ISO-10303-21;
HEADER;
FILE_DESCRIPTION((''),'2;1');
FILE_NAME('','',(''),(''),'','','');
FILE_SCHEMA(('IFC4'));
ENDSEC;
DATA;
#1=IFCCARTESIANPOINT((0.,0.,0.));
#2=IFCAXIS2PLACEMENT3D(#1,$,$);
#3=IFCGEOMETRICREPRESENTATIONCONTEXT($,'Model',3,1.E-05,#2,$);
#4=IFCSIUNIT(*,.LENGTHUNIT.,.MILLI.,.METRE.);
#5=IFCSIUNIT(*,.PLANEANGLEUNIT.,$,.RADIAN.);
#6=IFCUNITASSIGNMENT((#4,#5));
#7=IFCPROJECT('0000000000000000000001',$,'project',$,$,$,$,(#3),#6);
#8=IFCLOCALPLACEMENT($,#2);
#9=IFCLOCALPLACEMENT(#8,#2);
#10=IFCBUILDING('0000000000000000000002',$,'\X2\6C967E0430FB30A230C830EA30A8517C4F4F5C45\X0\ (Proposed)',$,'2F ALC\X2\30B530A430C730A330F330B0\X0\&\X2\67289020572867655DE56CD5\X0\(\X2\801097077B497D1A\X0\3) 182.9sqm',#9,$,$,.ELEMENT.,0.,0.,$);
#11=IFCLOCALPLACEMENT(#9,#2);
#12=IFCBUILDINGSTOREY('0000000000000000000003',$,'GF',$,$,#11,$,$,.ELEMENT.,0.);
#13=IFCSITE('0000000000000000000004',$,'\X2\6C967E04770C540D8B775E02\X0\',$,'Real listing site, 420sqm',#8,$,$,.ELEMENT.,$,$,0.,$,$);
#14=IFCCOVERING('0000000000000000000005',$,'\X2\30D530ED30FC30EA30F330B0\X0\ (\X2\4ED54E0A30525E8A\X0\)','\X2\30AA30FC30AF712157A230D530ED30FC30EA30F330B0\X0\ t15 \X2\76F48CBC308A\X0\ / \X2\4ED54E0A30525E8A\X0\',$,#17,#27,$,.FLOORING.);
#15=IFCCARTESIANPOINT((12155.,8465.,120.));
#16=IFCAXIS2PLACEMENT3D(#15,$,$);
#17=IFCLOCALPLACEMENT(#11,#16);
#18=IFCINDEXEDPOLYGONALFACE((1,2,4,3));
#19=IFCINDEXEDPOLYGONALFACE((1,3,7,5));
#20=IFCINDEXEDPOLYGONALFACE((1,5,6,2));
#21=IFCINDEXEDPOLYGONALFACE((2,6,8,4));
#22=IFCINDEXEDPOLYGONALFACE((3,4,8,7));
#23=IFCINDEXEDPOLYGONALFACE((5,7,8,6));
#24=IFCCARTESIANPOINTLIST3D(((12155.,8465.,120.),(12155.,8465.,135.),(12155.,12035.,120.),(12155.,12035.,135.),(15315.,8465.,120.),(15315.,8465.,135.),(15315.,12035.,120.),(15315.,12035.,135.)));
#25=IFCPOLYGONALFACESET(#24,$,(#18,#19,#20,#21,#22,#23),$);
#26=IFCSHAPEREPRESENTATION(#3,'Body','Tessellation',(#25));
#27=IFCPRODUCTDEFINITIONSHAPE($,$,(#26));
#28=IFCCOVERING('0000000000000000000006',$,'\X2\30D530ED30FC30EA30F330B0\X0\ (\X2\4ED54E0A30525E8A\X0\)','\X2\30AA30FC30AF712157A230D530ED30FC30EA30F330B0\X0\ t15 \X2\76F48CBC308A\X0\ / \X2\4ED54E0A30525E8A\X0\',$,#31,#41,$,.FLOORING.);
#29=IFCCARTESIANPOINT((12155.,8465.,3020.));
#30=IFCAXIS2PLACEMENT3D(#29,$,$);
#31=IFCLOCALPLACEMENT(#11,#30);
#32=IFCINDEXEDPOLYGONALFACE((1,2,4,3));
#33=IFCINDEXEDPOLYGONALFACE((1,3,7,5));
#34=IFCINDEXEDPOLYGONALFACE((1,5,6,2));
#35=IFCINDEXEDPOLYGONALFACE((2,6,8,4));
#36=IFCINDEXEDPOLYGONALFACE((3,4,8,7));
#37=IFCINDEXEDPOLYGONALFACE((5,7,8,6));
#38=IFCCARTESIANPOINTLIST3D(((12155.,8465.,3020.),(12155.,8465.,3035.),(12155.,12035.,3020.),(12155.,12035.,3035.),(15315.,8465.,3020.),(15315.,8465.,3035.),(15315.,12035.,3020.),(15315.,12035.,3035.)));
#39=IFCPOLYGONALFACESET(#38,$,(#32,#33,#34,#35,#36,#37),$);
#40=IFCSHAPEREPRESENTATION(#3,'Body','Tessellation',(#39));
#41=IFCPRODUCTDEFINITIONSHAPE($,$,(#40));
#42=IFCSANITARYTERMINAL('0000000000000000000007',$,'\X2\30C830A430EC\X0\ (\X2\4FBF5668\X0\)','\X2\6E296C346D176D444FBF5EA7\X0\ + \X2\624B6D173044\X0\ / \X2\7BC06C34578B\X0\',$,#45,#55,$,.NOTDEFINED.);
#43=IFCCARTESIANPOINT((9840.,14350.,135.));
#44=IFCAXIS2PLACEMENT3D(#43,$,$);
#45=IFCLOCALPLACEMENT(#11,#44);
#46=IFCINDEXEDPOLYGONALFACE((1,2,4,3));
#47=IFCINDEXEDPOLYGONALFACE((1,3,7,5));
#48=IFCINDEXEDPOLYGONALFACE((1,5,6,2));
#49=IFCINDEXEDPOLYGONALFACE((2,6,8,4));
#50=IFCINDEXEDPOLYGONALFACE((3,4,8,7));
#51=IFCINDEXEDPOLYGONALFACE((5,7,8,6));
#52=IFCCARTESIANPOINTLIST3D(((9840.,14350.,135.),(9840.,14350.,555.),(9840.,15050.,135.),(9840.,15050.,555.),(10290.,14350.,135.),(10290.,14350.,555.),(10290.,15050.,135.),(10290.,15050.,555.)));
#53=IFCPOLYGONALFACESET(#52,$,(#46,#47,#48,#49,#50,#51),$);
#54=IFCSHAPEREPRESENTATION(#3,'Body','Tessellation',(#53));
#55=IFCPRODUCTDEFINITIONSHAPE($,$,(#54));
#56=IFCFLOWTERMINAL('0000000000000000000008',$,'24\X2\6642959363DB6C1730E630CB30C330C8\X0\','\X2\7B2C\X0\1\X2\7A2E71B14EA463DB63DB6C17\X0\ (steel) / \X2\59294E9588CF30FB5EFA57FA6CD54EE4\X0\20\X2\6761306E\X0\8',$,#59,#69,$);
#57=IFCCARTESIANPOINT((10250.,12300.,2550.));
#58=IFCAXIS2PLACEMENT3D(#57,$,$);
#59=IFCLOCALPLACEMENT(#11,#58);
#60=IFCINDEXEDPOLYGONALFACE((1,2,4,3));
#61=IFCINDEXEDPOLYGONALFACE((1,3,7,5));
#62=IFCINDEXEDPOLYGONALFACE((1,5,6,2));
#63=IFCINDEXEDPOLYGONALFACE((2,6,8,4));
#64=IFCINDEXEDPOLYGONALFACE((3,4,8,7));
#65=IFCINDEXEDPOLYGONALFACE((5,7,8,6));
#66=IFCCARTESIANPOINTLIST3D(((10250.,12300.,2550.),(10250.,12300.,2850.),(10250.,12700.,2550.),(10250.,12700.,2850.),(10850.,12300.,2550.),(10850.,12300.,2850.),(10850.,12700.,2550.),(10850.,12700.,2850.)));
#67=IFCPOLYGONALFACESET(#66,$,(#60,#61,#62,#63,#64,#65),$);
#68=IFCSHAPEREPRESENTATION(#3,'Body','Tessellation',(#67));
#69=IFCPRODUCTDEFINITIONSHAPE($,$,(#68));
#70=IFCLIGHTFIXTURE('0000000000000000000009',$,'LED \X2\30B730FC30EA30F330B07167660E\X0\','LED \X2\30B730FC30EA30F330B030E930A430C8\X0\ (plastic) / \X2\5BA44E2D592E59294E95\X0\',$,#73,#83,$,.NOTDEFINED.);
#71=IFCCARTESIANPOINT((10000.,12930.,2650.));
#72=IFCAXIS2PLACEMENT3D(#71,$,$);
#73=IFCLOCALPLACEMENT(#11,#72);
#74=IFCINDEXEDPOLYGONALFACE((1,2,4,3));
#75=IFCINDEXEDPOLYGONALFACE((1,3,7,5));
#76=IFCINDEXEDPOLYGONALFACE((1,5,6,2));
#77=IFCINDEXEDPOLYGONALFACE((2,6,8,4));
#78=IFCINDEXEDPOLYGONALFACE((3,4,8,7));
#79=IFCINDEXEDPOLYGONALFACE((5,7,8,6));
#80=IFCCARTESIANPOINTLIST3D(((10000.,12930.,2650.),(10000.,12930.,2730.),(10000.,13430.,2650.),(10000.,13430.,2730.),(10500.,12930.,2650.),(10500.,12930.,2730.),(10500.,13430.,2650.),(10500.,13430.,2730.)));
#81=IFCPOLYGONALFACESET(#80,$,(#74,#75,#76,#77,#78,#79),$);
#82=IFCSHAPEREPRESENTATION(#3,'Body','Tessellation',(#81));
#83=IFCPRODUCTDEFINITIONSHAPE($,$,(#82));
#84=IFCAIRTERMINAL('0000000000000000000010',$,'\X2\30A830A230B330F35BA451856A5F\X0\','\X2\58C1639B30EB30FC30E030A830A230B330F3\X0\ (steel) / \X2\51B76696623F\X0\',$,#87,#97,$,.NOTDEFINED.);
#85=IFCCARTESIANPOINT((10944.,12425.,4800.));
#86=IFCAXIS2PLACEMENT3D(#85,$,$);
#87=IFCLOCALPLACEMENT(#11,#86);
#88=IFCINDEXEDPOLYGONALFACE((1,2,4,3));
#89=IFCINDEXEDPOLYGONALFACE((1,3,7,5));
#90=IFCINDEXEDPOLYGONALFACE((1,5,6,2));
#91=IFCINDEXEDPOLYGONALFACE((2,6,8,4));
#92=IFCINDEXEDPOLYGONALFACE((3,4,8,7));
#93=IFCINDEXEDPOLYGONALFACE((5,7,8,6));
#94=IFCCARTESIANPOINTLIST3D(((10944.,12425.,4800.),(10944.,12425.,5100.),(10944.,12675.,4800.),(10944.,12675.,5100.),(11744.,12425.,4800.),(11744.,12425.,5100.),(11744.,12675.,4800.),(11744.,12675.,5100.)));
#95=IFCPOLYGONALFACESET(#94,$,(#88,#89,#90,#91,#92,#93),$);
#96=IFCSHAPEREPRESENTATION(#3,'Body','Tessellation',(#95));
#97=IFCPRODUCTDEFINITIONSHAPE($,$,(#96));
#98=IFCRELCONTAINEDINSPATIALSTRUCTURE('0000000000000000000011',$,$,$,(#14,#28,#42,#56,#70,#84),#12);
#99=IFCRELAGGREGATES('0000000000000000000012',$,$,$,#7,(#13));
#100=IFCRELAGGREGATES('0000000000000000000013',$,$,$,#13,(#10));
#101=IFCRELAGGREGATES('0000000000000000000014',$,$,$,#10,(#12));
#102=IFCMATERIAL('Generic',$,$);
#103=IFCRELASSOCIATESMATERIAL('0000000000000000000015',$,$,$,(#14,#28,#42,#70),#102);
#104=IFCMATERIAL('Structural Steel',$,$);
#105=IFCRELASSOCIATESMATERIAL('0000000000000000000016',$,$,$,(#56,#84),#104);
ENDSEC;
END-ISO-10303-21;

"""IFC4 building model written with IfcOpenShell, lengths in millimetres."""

from ifc_helpers import new_model, si_unit, frame, frame_2d, origin, place, context, project, spatial, rectangle, extrude, material, element, save


model = new_model("IFC4")

# Units and contexts
model_context = context("Model", 3, precision=1e-05, world=origin())
ifc_project = project(units=[si_unit("LENGTHUNIT", "METRE", prefix="MILLI"), si_unit("PLANEANGLEUNIT", "RADIAN")], contexts=[model_context])

# Site, building, storey
site_placement = place(None, origin())
site = spatial("IfcSite", under=ifc_project, at=site_placement, Name="沖縄県名護市", ObjectType="Real listing site, 420sqm", CompositionType="ELEMENT", RefElevation=0.0)
building_placement = place(site_placement, origin())
building = spatial("IfcBuilding", under=site, at=building_placement, Name="沖縄・アトリエ兼住居 (Proposed)", ObjectType="2F ALCサイディング&木造在来工法(耐震等級3) 182.9sqm", CompositionType="ELEMENT", ElevationOfRefHeight=0.0, ElevationOfTerrain=0.0)
storey_placement = place(building_placement, origin())
storey = spatial("IfcBuildingStorey", under=building, at=storey_placement, Name="GF", CompositionType="ELEMENT", Elevation=0.0)

# Coverings
ifc_material_1 = material(Name="Generic")
covering_1_placement = place(storey_placement, frame((12155.0, 8465.0, 120.0)))
element("IfcCovering", 1, at=covering_1_placement, inside=storey, material=ifc_material_1, Name="フローリング (仕上げ床)", Description="オーク無垢フローリング t15 直貼り / 仕上げ床", PredefinedType="FLOORING", context=model_context, shape_type="SweptSolid", body=[
    extrude(rectangle(XDim=3160.0, YDim=3570.0, at=frame_2d((1580.0, 1785.0))), frame((12155.0, 8465.0, 120.0)), (0.0, 0.0, 1.0), 15.0),
])
covering_2_placement = place(storey_placement, frame((12155.0, 8465.0, 3020.0)))
element("IfcCovering", 2, at=covering_2_placement, inside=storey, material=ifc_material_1, Name="フローリング (仕上げ床)", Description="オーク無垢フローリング t15 直貼り / 仕上げ床", PredefinedType="FLOORING", context=model_context, shape_type="SweptSolid", body=[
    extrude(rectangle(XDim=3160.0, YDim=3570.0, at=frame_2d((1580.0, 1785.0))), frame((12155.0, 8465.0, 3020.0)), (0.0, 0.0, 1.0), 15.0),
])

# Sanitary terminal
sanitary_terminal_placement = place(storey_placement, frame((9840.0, 14350.0, 135.0)))
element("IfcSanitaryTerminal", 3, at=sanitary_terminal_placement, inside=storey, material=ifc_material_1, Name="トイレ (便器)", Description="温水洗浄便座 + 手洗い / 節水型", PredefinedType="NOTDEFINED", context=model_context, shape_type="SweptSolid", body=[
    extrude(rectangle(XDim=450.0, YDim=700.0, at=frame_2d((225.0, 350.0))), frame((9840.0, 14350.0, 135.0)), (0.0, 0.0, 1.0), 420.0),
])

# Flow terminal
ifc_material_2 = material(Name="Structural Steel")
flow_terminal_placement = place(storey_placement, frame((10250.0, 12300.0, 2550.0)))
element("IfcFlowTerminal", 4, at=flow_terminal_placement, inside=storey, material=ifc_material_2, Name="24時間換気ユニット", Description="第1種熱交換換気 (steel) / 天井裏・建基法令20条の8", context=model_context, shape_type="SweptSolid", body=[
    extrude(rectangle(XDim=600.0, YDim=400.0, at=frame_2d((300.0, 200.0))), frame((10250.0, 12300.0, 2550.0)), (0.0, 0.0, 1.0), 300.0),
])

# Light fixture
light_fixture_placement = place(storey_placement, frame((10000.0, 12930.0, 2650.0)))
element("IfcLightFixture", 5, at=light_fixture_placement, inside=storey, material=ifc_material_1, Name="LED シーリング照明", Description="LED シーリングライト (plastic) / 室中央天井", PredefinedType="NOTDEFINED", context=model_context, shape_type="SweptSolid", body=[
    extrude(rectangle(XDim=500.0, YDim=500.0, at=frame_2d((250.0, 250.0))), frame((10000.0, 12930.0, 2650.0)), (0.0, 0.0, 1.0), 80.0),
])

# Air terminal
air_terminal_placement = place(storey_placement, frame((10944.0, 12425.0, 4800.0)))
element("IfcAirTerminal", 6, at=air_terminal_placement, inside=storey, material=ifc_material_2, Name="エアコン室内機", Description="壁掛ルームエアコン (steel) / 冷暖房", PredefinedType="NOTDEFINED", context=model_context, shape_type="SweptSolid", body=[
    extrude(rectangle(XDim=800.0, YDim=250.0, at=frame_2d((400.0, 125.0))), frame((10944.0, 12425.0, 4800.0)), (0.0, 0.0, 1.0), 300.0),
])

save(model, "model.ifc")
